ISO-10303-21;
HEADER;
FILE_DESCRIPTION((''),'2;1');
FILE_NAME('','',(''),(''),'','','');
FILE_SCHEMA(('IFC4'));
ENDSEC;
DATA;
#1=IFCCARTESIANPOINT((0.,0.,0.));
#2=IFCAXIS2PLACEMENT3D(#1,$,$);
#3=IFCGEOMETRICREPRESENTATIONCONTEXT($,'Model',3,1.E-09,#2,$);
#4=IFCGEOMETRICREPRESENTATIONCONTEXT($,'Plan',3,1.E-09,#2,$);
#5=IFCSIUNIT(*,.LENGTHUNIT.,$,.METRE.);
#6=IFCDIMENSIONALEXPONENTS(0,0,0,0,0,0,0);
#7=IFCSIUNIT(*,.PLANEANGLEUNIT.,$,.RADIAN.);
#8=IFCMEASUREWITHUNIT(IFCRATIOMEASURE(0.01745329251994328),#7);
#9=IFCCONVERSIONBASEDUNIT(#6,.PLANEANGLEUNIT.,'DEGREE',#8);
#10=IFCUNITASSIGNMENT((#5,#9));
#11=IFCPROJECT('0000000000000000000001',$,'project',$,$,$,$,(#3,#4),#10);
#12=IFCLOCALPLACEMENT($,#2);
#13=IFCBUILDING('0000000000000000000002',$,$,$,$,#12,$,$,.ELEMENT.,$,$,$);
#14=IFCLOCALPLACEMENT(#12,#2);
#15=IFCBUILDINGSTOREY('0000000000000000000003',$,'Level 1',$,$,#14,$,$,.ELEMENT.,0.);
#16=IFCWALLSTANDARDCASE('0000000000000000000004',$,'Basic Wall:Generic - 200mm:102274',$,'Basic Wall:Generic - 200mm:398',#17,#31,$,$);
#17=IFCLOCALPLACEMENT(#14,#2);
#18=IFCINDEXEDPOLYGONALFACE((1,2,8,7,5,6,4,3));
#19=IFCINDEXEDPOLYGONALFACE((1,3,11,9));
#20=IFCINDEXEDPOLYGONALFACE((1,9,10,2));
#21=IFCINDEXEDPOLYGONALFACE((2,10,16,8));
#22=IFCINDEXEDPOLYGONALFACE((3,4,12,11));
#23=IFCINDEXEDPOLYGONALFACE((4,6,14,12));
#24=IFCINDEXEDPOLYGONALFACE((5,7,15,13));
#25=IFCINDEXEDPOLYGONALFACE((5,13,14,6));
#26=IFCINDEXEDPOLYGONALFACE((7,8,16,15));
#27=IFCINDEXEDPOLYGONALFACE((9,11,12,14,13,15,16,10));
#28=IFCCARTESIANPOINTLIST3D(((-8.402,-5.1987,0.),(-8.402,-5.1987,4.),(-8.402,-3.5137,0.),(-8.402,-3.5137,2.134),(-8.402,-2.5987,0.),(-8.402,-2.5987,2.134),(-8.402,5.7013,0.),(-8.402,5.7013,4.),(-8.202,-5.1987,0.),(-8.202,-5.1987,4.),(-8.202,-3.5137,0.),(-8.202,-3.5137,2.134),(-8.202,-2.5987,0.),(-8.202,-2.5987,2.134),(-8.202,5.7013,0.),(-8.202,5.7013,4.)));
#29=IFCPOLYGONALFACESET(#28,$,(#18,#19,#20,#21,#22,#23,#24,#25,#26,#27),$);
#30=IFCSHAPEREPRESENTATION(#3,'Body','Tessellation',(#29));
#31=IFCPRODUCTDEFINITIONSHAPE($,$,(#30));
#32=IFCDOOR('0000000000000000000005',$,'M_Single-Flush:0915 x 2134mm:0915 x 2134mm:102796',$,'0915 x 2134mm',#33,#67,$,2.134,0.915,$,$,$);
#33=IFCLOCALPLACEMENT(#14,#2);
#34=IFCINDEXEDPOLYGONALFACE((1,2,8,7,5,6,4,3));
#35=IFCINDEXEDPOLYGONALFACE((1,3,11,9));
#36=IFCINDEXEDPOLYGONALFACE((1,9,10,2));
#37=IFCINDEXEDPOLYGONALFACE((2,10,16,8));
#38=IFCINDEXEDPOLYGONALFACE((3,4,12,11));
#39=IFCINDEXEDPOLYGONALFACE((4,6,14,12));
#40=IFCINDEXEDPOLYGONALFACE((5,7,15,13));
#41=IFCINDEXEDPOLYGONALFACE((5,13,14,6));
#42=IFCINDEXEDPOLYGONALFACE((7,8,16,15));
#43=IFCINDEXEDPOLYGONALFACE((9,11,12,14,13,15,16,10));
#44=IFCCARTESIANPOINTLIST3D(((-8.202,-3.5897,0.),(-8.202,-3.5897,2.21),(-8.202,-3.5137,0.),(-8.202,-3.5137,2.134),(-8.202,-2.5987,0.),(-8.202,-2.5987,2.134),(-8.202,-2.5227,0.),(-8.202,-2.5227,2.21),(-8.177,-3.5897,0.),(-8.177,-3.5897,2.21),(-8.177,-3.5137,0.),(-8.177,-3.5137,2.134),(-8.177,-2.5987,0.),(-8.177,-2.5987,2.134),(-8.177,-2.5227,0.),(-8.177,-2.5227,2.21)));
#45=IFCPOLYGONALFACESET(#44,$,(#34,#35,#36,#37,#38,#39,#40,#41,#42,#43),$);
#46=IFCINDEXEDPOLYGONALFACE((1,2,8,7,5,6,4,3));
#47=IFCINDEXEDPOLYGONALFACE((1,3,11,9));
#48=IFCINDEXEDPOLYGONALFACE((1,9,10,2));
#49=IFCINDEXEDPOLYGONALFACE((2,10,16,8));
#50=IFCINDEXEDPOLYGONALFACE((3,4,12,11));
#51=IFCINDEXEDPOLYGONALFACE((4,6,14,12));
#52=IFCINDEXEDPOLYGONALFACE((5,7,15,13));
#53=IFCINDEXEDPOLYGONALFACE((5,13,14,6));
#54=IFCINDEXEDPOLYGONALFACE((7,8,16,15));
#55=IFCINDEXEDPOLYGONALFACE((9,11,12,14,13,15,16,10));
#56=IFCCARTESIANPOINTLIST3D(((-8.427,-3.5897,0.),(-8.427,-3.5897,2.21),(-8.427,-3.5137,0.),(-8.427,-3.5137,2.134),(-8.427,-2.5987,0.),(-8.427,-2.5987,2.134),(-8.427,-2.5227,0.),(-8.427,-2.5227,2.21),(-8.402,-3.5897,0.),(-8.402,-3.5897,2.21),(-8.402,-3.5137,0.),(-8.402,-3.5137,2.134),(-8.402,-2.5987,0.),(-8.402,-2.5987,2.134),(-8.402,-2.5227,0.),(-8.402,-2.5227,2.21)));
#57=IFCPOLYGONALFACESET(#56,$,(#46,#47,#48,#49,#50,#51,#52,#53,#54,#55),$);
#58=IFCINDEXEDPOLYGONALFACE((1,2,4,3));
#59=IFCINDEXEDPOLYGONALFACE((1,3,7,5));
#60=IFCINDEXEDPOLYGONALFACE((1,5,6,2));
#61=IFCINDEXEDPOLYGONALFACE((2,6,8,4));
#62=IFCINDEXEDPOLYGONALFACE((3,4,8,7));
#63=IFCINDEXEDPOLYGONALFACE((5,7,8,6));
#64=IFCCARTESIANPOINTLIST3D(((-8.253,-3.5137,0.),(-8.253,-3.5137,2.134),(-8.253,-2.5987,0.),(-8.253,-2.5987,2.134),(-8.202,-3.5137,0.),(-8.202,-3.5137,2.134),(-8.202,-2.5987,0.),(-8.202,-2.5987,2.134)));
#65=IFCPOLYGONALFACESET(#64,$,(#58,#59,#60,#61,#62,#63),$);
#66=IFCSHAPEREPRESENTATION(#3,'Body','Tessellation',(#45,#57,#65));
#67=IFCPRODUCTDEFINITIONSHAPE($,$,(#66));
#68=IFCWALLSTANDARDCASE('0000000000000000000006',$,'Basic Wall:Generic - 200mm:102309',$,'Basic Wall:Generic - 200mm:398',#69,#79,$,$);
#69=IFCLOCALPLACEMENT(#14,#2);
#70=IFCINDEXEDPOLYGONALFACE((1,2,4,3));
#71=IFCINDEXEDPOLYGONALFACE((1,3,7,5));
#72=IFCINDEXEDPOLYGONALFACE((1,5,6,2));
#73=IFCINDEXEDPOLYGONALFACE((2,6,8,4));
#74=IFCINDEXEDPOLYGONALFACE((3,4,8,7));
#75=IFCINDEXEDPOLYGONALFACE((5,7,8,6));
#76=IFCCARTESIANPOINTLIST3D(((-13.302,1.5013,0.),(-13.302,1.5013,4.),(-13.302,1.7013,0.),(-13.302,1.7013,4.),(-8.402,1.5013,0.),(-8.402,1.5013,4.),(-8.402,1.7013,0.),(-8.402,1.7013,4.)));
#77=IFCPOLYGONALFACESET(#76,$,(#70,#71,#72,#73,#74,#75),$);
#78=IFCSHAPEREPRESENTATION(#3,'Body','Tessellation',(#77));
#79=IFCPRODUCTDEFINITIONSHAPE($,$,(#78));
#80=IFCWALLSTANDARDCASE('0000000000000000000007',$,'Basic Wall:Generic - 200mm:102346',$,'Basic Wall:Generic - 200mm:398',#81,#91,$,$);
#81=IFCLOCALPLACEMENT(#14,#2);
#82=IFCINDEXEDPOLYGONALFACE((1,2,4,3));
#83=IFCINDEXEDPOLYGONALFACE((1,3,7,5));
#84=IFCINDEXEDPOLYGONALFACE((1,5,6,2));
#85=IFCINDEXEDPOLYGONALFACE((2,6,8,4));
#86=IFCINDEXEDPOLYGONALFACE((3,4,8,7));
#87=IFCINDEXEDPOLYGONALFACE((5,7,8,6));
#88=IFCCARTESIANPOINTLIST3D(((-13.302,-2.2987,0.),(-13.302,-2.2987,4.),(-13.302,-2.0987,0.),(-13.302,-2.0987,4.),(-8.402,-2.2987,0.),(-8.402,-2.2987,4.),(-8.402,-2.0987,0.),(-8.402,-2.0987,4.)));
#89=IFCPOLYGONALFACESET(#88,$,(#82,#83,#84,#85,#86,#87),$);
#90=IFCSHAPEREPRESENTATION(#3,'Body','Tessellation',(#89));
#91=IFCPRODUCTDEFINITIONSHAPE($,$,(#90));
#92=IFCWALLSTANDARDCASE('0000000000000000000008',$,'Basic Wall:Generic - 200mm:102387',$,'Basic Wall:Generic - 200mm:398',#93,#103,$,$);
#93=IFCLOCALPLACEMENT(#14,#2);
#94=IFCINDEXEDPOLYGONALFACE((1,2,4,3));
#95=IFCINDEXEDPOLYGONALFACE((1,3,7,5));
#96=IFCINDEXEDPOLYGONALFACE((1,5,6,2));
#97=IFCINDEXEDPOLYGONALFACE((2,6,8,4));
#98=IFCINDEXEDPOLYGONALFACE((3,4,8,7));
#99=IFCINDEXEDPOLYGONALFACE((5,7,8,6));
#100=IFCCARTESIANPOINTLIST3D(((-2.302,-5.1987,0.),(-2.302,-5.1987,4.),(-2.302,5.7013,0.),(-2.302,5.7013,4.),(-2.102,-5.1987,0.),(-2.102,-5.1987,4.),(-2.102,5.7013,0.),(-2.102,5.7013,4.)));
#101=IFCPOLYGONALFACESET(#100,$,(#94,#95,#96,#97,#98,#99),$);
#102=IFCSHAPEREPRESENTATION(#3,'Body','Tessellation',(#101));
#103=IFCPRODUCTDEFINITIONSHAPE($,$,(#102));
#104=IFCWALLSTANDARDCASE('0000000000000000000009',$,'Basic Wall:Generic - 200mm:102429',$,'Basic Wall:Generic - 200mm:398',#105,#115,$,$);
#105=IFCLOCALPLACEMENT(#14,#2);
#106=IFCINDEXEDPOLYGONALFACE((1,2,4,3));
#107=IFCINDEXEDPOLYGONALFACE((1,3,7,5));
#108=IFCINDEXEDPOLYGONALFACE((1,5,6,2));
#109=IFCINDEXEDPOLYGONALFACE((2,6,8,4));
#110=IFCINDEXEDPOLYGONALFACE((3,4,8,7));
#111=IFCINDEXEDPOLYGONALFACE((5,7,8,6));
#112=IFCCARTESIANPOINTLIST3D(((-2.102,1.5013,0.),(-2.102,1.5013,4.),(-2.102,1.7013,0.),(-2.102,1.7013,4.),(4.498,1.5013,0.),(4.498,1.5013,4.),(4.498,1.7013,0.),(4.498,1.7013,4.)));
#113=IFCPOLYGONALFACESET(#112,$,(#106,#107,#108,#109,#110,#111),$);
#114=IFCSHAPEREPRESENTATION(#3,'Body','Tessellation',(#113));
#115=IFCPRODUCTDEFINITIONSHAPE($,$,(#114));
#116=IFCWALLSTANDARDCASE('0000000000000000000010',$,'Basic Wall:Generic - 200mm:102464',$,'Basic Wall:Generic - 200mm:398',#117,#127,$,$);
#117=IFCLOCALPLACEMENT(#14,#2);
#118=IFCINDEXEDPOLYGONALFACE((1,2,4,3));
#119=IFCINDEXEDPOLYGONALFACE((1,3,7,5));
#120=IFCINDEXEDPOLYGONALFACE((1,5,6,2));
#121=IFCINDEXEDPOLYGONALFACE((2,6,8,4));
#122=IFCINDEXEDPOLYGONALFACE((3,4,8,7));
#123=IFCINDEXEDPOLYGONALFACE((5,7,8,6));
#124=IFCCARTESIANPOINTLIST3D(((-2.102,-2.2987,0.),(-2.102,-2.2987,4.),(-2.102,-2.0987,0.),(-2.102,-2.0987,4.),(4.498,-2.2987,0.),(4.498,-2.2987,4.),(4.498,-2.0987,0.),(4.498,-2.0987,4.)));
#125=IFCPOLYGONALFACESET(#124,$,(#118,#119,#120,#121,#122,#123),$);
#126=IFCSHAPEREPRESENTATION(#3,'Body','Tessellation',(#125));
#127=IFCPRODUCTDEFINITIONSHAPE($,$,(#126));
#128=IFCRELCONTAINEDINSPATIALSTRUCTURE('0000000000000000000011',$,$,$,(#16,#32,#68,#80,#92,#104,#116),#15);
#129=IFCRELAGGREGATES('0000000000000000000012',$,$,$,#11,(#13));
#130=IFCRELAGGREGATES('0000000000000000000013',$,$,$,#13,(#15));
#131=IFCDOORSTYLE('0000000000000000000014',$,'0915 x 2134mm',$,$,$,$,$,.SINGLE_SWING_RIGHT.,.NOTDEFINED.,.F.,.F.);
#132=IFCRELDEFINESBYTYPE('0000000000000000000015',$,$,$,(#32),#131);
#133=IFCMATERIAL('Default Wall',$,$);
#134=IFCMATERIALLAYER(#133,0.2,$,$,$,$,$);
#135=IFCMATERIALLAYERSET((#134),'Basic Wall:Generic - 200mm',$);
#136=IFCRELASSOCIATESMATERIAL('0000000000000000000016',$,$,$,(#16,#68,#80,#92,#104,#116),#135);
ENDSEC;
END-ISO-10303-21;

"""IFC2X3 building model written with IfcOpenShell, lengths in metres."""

from ifc_helpers import new_model, entity, si_unit, converted_unit, frame, frame_2d, origin, origin_2d_with_axis, place, context, project, spatial, polyline, rectangle, outline, extrude, source, transform, mapped, material, layer, layer_set, layer_usage, type_object, type_shapes, element, fill, save


model = new_model("IFC2X3")

# Units and contexts
model_context = context("Model", 3, precision=1e-09, world=origin())
plan_context = context("Plan", 3, precision=1e-09, world=origin())
ifc_project = project(units=[si_unit("LENGTHUNIT", "METRE"), converted_unit("PLANEANGLEUNIT", "DEGREE", entity("IfcRatioMeasure", 0.01745329251994328), si_unit("PLANEANGLEUNIT", "RADIAN"), dimensions=[0, 0, 0, 0, 0, 0, 0])], contexts=[model_context, plan_context])

# Building, storey
building_placement = place(None, origin())
building = spatial("IfcBuilding", under=ifc_project, at=building_placement, CompositionType="ELEMENT")
storey_placement = place(building_placement, origin())
storey = spatial("IfcBuildingStorey", under=building, at=storey_placement, Name="Level 1", CompositionType="ELEMENT", Elevation=0.0)

# Shared definitions
ifc_material = material(Name="Default Wall")
ifc_layer = layer(ifc_material, 0.2)
ifc_layer_set = layer_set([ifc_layer], Name="Basic Wall:Generic - 200mm")

# Wall, opening, door
ifc_layer_usage_1 = layer_usage(ifc_layer_set, "AXIS2", "NEGATIVE", 0.1)
wall_1_placement = place(storey_placement, frame((-8.302, 5.7013, 0.0), z_axis=(0.0, 0.0, 1.0), x_axis=(0.0, -1.0, 0.0)))
wall_1 = element("IfcWallStandardCase", 1, at=wall_1_placement, inside=storey, material=ifc_layer_usage_1, Name="Basic Wall:Generic - 200mm:102274", ObjectType="Basic Wall:Generic - 200mm:398", context=model_context, shape_type="SweptSolid", body=[
    extrude(rectangle(XDim=10.9, YDim=0.2, at=frame_2d((5.45, 0.0), x_axis=(-1.0, 0.0))), origin(), (0.0, 0.0, 1.0), 4.0),
])
opening_1_placement = place(wall_1_placement, frame((8.3, -0.1, 0.0)))
opening_1 = element("IfcOpeningElement", 2, at=opening_1_placement, cuts=wall_1, ObjectType="Opening", context=model_context, shape_type="SweptSolid", body=[
    extrude(rectangle(XDim=0.915, YDim=2.134, at=frame_2d((1.067, 0.4575), x_axis=(0.0, 1.0))), frame((0.0, 0.0, 0.0), z_axis=(0.0, 1.0, 0.0), x_axis=(0.0, 0.0, 1.0)), (0.0, 0.0, 1.0), 0.2),
])
door_style = type_object("IfcDoorStyle", Name="0915 x 2134mm", ConstructionType="NOTDEFINED", OperationType="SINGLE_SWING_RIGHT", ParameterTakesPrecedence=False, Sizeable=False)
shared_shape_1 = source(origin(), model_context, "Body", "SweptSolid", [
    extrude(outline(polyline([(-0.5335, -1.124), (0.5335, -1.124), (0.5335, 1.086), (0.4575, 1.086), (0.4575, -1.048), (-0.4575, -1.048), (-0.4575, 1.086), (-0.5335, 1.086), (-0.5335, -1.124)])), frame((0.4575, 0.2, 1.086), z_axis=(0.0, 1.0, 0.0), x_axis=(1.0, 0.0, 0.0)), (0.0, 0.0, 1.0), 0.025),
    extrude(outline(polyline([(-1.124, -0.5335), (1.086, -0.5335), (1.086, -0.4575), (-1.048, -0.4575), (-1.048, 0.4575), (1.086, 0.4575), (1.086, 0.5335), (-1.124, 0.5335), (-1.124, -0.5335)])), frame((0.4575, -0.025, 1.086), z_axis=(0.0, 1.0, 0.0), x_axis=(0.0, 0.0, -1.0)), (0.0, 0.0, 1.0), 0.025),
    extrude(rectangle(XDim=0.051, YDim=0.915, at=origin_2d_with_axis()), frame((0.4575, 0.1745, 0.0), z_axis=(0.0, 0.0, 1.0), x_axis=(0.0, 1.0, 0.0)), (0.0, 0.0, 1.0), 2.134),
])
type_shapes(door_style, [shared_shape_1])
door_placement = place(opening_1_placement, origin())
door = element("IfcDoor", 3, at=door_placement, inside=storey, type_object=door_style, Name="M_Single-Flush:0915 x 2134mm:0915 x 2134mm:102796", ObjectType="0915 x 2134mm", OverallHeight=2.134, OverallWidth=0.915, context=model_context, shape_type="MappedRepresentation", body=[
    mapped(shared_shape_1, transform((0.0, 0.0, 0.0), scale=1.0)),
])
fill(opening_1, door)

# Walls
ifc_layer_usage_2 = layer_usage(ifc_layer_set, "AXIS2", "NEGATIVE", 0.1)
wall_2_placement = place(storey_placement, frame((-13.302, 1.6013, 0.0)))
element("IfcWallStandardCase", 4, at=wall_2_placement, inside=storey, material=ifc_layer_usage_2, Name="Basic Wall:Generic - 200mm:102309", ObjectType="Basic Wall:Generic - 200mm:398", context=model_context, shape_type="SweptSolid", body=[
    extrude(rectangle(XDim=4.9, YDim=0.2, at=frame_2d((2.45, 0.0), x_axis=(-1.0, 0.0))), origin(), (0.0, 0.0, 1.0), 4.0),
])
ifc_layer_usage_3 = layer_usage(ifc_layer_set, "AXIS2", "NEGATIVE", 0.1)
wall_3_placement = place(storey_placement, frame((-13.302, -2.1987, 0.0)))
element("IfcWallStandardCase", 5, at=wall_3_placement, inside=storey, material=ifc_layer_usage_3, Name="Basic Wall:Generic - 200mm:102346", ObjectType="Basic Wall:Generic - 200mm:398", context=model_context, shape_type="SweptSolid", body=[
    extrude(rectangle(XDim=4.9, YDim=0.2, at=frame_2d((2.45, 0.0), x_axis=(-1.0, 0.0))), origin(), (0.0, 0.0, 1.0), 4.0),
])
ifc_layer_usage_4 = layer_usage(ifc_layer_set, "AXIS2", "NEGATIVE", 0.1)
wall_4_placement = place(storey_placement, frame((-2.202, 5.7013, 0.0), z_axis=(0.0, 0.0, 1.0), x_axis=(0.0, -1.0, 0.0)))
element("IfcWallStandardCase", 6, at=wall_4_placement, inside=storey, material=ifc_layer_usage_4, Name="Basic Wall:Generic - 200mm:102387", ObjectType="Basic Wall:Generic - 200mm:398", context=model_context, shape_type="SweptSolid", body=[
    extrude(rectangle(XDim=10.9, YDim=0.2, at=frame_2d((5.45, 0.0), x_axis=(-1.0, 0.0))), origin(), (0.0, 0.0, 1.0), 4.0),
])
ifc_layer_usage_5 = layer_usage(ifc_layer_set, "AXIS2", "NEGATIVE", 0.1)
wall_5_placement = place(storey_placement, frame((-2.102, 1.6013, 0.0)))
element("IfcWallStandardCase", 7, at=wall_5_placement, inside=storey, material=ifc_layer_usage_5, Name="Basic Wall:Generic - 200mm:102429", ObjectType="Basic Wall:Generic - 200mm:398", context=model_context, shape_type="SweptSolid", body=[
    extrude(rectangle(XDim=6.6, YDim=0.2, at=frame_2d((3.3, 0.0), x_axis=(-1.0, 0.0))), origin(), (0.0, 0.0, 1.0), 4.0),
])
ifc_layer_usage_6 = layer_usage(ifc_layer_set, "AXIS2", "NEGATIVE", 0.1)
wall_6_placement = place(storey_placement, frame((-2.102, -2.1987, 0.0)))
element("IfcWallStandardCase", 8, at=wall_6_placement, inside=storey, material=ifc_layer_usage_6, Name="Basic Wall:Generic - 200mm:102464", ObjectType="Basic Wall:Generic - 200mm:398", context=model_context, shape_type="SweptSolid", body=[
    extrude(rectangle(XDim=6.6, YDim=0.2, at=frame_2d((3.3, 0.0), x_axis=(-1.0, 0.0))), origin(), (0.0, 0.0, 1.0), 4.0),
])

save(model, "model.ifc")
